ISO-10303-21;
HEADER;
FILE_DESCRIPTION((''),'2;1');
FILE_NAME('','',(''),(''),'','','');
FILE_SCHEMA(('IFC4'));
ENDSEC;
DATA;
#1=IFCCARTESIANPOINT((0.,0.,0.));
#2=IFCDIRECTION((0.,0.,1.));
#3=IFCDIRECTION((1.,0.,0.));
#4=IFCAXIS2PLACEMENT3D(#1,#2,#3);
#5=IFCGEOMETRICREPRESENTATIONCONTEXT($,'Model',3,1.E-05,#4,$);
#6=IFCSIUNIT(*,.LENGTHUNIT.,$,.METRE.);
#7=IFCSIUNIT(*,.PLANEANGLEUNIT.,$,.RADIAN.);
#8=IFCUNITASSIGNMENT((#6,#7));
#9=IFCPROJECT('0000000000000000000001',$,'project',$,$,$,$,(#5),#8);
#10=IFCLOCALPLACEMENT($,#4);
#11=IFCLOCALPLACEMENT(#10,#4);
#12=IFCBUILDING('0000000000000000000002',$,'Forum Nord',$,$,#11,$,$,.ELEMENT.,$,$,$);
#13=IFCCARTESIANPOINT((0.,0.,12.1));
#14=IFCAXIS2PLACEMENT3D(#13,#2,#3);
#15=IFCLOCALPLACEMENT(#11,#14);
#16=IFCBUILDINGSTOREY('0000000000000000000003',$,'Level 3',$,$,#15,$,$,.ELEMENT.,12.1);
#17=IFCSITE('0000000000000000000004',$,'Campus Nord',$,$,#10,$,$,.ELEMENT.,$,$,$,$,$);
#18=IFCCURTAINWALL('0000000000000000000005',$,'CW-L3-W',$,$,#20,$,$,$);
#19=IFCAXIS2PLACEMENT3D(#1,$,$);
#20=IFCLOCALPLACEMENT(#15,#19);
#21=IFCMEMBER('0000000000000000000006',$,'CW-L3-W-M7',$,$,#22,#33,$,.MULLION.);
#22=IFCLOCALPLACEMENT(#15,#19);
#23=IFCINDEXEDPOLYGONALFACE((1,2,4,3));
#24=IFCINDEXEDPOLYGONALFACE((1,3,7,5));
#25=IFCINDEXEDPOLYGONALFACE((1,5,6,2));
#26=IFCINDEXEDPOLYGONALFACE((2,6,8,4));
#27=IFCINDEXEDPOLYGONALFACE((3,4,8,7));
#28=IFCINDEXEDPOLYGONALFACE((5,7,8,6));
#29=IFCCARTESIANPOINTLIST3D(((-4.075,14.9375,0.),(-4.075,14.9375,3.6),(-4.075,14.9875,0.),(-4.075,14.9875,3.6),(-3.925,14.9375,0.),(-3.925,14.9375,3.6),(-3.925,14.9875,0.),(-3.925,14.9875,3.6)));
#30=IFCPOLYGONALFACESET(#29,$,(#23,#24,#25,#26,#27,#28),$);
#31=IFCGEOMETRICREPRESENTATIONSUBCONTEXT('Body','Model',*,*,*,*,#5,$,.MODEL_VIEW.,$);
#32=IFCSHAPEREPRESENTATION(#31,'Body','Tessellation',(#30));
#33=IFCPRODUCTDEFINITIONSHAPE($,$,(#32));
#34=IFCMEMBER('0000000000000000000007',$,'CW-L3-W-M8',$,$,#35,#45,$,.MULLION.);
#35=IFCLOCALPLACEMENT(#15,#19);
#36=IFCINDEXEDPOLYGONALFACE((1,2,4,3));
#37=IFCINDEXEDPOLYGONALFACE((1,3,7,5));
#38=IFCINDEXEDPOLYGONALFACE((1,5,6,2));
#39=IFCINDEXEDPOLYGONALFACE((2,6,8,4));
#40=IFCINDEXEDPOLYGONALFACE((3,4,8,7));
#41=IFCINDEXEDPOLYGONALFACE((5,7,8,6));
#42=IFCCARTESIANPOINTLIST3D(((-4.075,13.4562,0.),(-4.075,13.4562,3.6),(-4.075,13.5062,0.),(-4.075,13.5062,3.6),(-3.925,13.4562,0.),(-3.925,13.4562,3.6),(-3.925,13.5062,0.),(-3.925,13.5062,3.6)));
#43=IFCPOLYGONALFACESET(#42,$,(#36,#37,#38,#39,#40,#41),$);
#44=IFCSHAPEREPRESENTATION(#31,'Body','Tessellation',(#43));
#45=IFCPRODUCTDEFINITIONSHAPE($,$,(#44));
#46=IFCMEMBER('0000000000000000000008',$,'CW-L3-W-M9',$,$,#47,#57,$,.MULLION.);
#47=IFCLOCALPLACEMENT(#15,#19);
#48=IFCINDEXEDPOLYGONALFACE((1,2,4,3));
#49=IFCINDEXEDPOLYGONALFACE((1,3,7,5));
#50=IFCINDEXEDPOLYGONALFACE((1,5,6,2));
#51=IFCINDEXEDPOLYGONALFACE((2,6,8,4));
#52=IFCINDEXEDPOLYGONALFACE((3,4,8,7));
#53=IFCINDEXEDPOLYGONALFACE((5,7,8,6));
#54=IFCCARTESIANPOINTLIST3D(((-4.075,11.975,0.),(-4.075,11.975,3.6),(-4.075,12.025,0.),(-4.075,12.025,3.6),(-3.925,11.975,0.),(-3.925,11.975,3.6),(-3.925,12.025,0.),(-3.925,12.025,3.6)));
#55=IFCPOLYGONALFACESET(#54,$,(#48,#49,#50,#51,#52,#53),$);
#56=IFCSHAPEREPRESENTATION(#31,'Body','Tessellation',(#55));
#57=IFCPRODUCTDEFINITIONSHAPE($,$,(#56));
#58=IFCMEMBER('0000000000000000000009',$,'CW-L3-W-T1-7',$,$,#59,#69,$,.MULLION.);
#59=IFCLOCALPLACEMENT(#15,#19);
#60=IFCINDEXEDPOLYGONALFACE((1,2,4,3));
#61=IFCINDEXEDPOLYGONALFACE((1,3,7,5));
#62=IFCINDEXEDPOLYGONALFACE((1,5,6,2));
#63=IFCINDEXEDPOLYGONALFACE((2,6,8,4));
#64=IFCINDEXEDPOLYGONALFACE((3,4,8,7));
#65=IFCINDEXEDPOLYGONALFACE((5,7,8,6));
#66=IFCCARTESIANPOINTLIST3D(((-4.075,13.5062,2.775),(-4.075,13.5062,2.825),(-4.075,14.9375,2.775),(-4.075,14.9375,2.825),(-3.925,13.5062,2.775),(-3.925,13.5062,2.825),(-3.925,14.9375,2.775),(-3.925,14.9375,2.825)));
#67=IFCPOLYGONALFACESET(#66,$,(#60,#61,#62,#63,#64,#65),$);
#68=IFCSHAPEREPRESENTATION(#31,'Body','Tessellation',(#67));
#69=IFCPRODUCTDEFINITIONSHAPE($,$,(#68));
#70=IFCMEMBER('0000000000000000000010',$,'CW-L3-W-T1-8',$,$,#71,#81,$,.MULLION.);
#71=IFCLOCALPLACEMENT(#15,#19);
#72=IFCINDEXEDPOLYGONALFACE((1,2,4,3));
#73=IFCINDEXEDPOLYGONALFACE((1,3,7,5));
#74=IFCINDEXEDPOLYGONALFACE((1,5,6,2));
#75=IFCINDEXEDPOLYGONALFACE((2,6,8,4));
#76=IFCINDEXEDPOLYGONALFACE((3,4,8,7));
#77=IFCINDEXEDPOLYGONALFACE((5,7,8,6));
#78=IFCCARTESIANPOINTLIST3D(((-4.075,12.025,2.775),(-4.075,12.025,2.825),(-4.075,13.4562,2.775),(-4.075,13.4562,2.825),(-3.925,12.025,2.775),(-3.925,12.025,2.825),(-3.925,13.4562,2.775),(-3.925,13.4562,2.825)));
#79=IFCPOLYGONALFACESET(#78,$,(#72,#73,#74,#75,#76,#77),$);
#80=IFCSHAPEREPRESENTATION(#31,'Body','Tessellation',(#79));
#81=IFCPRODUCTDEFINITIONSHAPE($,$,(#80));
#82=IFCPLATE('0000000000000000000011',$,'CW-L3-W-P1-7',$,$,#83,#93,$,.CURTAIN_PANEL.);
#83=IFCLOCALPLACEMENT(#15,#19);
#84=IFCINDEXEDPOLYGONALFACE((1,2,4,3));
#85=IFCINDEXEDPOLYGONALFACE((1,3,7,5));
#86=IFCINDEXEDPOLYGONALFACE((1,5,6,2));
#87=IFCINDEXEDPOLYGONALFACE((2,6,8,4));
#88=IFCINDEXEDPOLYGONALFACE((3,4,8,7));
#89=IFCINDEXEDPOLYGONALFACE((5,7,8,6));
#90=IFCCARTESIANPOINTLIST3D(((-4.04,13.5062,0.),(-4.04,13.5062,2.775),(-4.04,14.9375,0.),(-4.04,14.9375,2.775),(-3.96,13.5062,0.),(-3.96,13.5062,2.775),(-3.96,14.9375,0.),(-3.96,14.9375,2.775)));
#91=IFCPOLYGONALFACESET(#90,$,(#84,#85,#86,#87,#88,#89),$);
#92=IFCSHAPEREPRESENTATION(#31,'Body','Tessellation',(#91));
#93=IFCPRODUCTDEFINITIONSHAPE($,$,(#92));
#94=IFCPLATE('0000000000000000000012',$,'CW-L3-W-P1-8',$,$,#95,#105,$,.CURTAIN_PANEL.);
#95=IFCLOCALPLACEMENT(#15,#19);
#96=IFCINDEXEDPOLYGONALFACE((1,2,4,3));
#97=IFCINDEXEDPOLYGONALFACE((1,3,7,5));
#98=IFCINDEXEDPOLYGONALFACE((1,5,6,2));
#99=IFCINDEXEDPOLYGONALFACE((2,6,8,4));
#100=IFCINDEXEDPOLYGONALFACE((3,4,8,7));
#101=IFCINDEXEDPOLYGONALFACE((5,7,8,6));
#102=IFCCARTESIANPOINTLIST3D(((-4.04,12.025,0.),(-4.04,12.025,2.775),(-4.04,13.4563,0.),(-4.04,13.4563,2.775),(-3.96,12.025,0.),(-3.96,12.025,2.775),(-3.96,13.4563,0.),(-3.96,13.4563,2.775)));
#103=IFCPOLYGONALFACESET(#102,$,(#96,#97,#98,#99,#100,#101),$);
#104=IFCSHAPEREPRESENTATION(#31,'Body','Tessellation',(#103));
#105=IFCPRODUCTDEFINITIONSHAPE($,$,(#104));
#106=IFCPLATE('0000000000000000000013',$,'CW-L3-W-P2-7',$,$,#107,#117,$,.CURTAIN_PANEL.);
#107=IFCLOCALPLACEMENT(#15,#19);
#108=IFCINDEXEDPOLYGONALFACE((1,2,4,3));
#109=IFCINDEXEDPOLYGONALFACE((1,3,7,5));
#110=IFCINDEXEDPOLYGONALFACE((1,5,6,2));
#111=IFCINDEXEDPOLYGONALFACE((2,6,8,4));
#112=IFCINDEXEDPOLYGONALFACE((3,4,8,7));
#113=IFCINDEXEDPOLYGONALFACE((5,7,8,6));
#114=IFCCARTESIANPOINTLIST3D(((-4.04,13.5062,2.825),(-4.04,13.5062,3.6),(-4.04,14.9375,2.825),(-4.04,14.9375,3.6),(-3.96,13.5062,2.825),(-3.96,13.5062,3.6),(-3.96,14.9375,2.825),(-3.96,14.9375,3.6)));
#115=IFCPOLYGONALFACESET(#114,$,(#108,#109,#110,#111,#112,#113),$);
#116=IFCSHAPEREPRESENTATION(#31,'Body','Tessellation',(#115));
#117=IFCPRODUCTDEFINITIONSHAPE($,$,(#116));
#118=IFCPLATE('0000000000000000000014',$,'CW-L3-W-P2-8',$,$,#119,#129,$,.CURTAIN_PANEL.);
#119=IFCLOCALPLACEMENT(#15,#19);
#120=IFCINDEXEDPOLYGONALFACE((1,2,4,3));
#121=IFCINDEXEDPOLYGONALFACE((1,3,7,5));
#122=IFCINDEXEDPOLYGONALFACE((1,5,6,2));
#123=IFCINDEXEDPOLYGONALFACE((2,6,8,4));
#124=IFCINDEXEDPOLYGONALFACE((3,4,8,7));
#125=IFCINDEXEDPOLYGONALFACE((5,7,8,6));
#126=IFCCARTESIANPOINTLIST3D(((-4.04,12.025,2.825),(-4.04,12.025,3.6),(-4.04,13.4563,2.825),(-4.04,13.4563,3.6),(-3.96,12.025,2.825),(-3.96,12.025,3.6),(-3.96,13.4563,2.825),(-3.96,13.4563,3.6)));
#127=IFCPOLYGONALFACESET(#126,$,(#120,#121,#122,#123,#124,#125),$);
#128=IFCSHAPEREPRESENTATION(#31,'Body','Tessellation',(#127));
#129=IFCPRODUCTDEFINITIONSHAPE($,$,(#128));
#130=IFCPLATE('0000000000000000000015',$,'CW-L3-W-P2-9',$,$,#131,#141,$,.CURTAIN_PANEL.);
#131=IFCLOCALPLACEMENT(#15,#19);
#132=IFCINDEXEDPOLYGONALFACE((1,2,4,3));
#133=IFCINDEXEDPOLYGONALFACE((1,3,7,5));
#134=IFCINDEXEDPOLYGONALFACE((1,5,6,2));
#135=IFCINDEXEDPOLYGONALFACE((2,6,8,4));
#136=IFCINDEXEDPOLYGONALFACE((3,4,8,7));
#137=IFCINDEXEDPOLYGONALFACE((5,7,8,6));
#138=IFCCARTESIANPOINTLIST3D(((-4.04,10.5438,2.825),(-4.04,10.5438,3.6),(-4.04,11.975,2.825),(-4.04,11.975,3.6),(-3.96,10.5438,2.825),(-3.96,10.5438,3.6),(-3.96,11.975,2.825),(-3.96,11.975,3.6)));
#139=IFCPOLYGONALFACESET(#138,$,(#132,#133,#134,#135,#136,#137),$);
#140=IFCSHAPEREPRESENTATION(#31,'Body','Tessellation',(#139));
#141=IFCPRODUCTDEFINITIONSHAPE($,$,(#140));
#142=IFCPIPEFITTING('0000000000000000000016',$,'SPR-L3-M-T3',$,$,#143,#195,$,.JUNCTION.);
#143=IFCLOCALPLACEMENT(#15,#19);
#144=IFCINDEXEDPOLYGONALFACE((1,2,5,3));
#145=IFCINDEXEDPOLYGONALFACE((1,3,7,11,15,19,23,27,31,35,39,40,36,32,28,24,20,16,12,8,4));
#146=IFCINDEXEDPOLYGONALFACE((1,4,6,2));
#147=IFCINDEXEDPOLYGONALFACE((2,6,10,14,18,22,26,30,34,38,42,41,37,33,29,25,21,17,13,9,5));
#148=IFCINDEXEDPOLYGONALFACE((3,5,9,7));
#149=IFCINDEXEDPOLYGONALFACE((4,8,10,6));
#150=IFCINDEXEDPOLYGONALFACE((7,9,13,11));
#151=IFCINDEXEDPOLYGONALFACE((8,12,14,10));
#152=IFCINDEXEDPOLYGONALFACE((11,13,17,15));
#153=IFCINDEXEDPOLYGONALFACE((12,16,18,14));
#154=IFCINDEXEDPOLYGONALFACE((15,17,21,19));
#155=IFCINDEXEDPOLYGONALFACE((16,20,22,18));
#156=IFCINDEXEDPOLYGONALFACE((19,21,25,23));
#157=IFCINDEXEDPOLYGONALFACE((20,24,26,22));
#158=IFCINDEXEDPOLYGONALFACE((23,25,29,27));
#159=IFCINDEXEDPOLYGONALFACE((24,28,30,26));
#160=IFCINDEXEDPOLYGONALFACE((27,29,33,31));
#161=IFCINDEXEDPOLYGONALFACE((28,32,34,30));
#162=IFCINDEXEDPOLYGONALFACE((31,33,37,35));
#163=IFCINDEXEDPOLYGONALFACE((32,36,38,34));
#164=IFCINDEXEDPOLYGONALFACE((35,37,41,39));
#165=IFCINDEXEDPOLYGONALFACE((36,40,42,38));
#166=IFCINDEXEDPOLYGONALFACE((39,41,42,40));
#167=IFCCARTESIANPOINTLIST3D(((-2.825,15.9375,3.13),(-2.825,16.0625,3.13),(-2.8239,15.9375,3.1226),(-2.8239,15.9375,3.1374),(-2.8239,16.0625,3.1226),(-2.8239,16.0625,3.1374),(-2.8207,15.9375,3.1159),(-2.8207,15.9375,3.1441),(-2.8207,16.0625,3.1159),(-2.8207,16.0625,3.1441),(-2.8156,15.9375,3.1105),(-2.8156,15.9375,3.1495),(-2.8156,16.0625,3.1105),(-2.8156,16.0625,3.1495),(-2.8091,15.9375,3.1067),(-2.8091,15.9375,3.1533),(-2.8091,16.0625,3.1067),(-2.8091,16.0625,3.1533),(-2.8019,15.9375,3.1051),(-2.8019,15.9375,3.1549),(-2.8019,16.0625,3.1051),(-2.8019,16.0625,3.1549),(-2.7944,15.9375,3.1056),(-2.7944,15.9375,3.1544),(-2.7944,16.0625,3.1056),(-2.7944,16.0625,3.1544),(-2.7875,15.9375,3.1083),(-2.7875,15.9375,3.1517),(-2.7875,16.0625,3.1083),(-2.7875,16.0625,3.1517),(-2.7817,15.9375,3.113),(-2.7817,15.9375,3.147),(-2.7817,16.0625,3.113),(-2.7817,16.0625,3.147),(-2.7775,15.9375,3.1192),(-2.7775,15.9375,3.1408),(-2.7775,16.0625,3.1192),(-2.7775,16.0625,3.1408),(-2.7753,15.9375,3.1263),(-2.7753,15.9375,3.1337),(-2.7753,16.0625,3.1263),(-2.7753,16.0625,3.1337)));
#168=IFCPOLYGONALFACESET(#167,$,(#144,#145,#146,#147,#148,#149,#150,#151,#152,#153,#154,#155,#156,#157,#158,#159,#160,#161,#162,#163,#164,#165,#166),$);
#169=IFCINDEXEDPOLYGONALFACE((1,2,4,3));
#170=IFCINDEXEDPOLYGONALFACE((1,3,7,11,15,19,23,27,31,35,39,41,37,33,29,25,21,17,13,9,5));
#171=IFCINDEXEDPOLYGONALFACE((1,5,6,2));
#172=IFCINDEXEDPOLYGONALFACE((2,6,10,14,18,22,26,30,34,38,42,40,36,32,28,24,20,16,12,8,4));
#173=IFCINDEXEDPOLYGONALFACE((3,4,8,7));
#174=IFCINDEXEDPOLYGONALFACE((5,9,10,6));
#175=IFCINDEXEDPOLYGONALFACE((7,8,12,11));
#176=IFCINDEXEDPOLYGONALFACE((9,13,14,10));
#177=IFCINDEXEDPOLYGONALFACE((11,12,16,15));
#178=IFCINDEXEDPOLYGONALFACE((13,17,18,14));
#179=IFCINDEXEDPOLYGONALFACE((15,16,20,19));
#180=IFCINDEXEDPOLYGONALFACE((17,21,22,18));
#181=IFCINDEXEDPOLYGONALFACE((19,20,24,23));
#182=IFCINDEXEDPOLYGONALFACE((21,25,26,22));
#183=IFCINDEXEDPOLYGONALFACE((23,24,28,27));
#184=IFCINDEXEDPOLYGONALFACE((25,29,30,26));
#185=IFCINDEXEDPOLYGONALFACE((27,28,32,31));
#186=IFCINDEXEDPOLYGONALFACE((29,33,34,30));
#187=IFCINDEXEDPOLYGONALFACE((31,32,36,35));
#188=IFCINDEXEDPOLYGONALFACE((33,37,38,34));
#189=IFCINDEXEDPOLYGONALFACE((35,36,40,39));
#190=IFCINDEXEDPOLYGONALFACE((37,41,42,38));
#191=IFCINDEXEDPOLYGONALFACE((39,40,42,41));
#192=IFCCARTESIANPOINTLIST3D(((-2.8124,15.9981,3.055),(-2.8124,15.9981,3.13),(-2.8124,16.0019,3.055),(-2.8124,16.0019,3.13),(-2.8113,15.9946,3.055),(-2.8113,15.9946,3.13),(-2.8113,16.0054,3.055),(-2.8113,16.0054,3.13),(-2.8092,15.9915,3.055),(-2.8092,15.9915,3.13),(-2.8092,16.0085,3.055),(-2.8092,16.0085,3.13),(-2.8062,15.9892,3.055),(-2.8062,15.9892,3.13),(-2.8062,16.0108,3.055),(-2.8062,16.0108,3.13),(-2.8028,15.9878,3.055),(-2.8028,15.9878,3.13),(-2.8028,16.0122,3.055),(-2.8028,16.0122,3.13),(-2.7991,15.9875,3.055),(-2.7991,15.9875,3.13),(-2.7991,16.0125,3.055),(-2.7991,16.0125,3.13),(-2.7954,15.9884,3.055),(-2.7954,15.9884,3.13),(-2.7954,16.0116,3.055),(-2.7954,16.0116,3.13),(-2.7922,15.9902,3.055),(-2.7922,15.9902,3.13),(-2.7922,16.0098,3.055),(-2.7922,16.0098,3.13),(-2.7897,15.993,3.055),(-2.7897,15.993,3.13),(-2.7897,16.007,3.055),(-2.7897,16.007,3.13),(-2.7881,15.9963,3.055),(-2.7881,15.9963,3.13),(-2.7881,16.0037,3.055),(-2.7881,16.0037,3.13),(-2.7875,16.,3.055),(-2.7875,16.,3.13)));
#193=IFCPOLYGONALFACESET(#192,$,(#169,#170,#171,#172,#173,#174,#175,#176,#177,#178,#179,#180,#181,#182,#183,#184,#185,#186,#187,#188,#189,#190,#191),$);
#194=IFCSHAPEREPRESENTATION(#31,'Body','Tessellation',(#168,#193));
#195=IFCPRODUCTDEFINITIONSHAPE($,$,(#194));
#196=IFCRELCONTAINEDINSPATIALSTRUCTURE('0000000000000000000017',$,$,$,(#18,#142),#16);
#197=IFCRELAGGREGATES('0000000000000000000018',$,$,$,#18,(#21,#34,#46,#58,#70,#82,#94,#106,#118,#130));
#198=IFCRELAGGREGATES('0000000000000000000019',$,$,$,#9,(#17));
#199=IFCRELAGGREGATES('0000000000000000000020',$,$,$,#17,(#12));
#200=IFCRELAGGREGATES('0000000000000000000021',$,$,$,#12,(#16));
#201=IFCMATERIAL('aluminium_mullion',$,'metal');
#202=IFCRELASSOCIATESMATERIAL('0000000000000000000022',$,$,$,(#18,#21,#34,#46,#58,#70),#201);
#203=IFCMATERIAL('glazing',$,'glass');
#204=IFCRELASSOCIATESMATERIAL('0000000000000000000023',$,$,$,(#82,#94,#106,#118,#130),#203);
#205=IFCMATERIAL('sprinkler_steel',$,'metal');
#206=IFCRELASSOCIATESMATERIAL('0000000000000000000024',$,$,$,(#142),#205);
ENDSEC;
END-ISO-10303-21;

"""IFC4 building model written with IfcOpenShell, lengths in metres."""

from ifc_helpers import new_model, si_unit, frame, frame_2d, origin_with_axes, origin_2d_with_axis, place, context, subcontext, project, spatial, rectangle, circle, extrude, material, element, aggregate, save


model = new_model("IFC4")

# Units and contexts
model_context = context("Model", 3, precision=1e-05, world=origin_with_axes())
body_context = subcontext(model_context, "Body", "Model", "MODEL_VIEW")
ifc_project = project(units=[si_unit("LENGTHUNIT", "METRE"), si_unit("PLANEANGLEUNIT", "RADIAN")], contexts=[model_context])

# Site, building, storey
site_placement = place(None, origin_with_axes())
site = spatial("IfcSite", under=ifc_project, at=site_placement, Name="Campus Nord", CompositionType="ELEMENT")
building_placement = place(site_placement, origin_with_axes())
building = spatial("IfcBuilding", under=site, at=building_placement, Name="Forum Nord", CompositionType="ELEMENT")
storey_placement = place(building_placement, frame((0.0, 0.0, 12.1), z_axis=(0.0, 0.0, 1.0), x_axis=(1.0, 0.0, 0.0)))
storey = spatial("IfcBuildingStorey", under=building, at=storey_placement, Name="Level 3", CompositionType="ELEMENT", Elevation=12.1)

# Curtain wall, members, plates
ifc_material_1 = material(Name="aluminium_mullion", Category="metal")
curtain_wall_placement = place(storey_placement, origin_with_axes())
curtain_wall = element("IfcCurtainWall", 1, at=curtain_wall_placement, inside=storey, material=ifc_material_1, Name="CW-L3-W")
member_1_placement = place(storey_placement, frame((-4.0, 14.9625, 0.0), z_axis=(0.0, 0.0, 1.0), x_axis=(0.0, -1.0, 0.0)))
member_1 = element("IfcMember", 2, at=member_1_placement, material=ifc_material_1, Name="CW-L3-W-M7", PredefinedType="MULLION", context=body_context, shape_type="SweptSolid", body=[
    extrude(rectangle(XDim=0.05, YDim=0.15, at=origin_2d_with_axis()), origin_with_axes(), (0.0, 0.0, 1.0), 3.6),
])
member_2_placement = place(storey_placement, frame((-4.0, 13.4812, 0.0), z_axis=(0.0, 0.0, 1.0), x_axis=(0.0, -1.0, 0.0)))
member_2 = element("IfcMember", 3, at=member_2_placement, material=ifc_material_1, Name="CW-L3-W-M8", PredefinedType="MULLION", context=body_context, shape_type="SweptSolid", body=[
    extrude(rectangle(XDim=0.05, YDim=0.15, at=origin_2d_with_axis()), origin_with_axes(), (0.0, 0.0, 1.0), 3.6),
])
member_3_placement = place(storey_placement, frame((-4.0, 12.0, 0.0), z_axis=(0.0, 0.0, 1.0), x_axis=(0.0, -1.0, 0.0)))
member_3 = element("IfcMember", 4, at=member_3_placement, material=ifc_material_1, Name="CW-L3-W-M9", PredefinedType="MULLION", context=body_context, shape_type="SweptSolid", body=[
    extrude(rectangle(XDim=0.05, YDim=0.15, at=origin_2d_with_axis()), origin_with_axes(), (0.0, 0.0, 1.0), 3.6),
])
member_4_placement = place(storey_placement, frame((-4.0, 14.9375, 2.8), z_axis=(0.0, -1.0, 0.0), x_axis=(1.0, 0.0, 0.0)))
member_4 = element("IfcMember", 5, at=member_4_placement, material=ifc_material_1, Name="CW-L3-W-T1-7", PredefinedType="MULLION", context=body_context, shape_type="SweptSolid", body=[
    extrude(rectangle(XDim=0.15, YDim=0.05, at=origin_2d_with_axis()), origin_with_axes(), (0.0, 0.0, 1.0), 1.4312),
])
member_5_placement = place(storey_placement, frame((-4.0, 13.4563, 2.8), z_axis=(0.0, -1.0, 0.0), x_axis=(1.0, 0.0, 0.0)))
member_5 = element("IfcMember", 6, at=member_5_placement, material=ifc_material_1, Name="CW-L3-W-T1-8", PredefinedType="MULLION", context=body_context, shape_type="SweptSolid", body=[
    extrude(rectangle(XDim=0.15, YDim=0.05, at=origin_2d_with_axis()), origin_with_axes(), (0.0, 0.0, 1.0), 1.4312),
])
ifc_material_2 = material(Name="glazing", Category="glass")
plate_1_placement = place(storey_placement, frame((-4.0, 14.9375, 0.0), z_axis=(0.0, 0.0, 1.0), x_axis=(0.0, -1.0, 0.0)))
plate_1 = element("IfcPlate", 7, at=plate_1_placement, material=ifc_material_2, Name="CW-L3-W-P1-7", PredefinedType="CURTAIN_PANEL", context=body_context, shape_type="SweptSolid", body=[
    extrude(rectangle(XDim=1.4312, YDim=0.08, at=frame_2d((0.7156, 0.0), x_axis=(1.0, 0.0))), origin_with_axes(), (0.0, 0.0, 1.0), 2.775),
])
plate_2_placement = place(storey_placement, frame((-4.0, 13.4563, 0.0), z_axis=(0.0, 0.0, 1.0), x_axis=(0.0, -1.0, 0.0)))
plate_2 = element("IfcPlate", 8, at=plate_2_placement, material=ifc_material_2, Name="CW-L3-W-P1-8", PredefinedType="CURTAIN_PANEL", context=body_context, shape_type="SweptSolid", body=[
    extrude(rectangle(XDim=1.4312, YDim=0.08, at=frame_2d((0.7156, 0.0), x_axis=(1.0, 0.0))), origin_with_axes(), (0.0, 0.0, 1.0), 2.775),
])
plate_3_placement = place(storey_placement, frame((-4.0, 14.9375, 2.825), z_axis=(0.0, 0.0, 1.0), x_axis=(0.0, -1.0, 0.0)))
plate_3 = element("IfcPlate", 9, at=plate_3_placement, material=ifc_material_2, Name="CW-L3-W-P2-7", PredefinedType="CURTAIN_PANEL", context=body_context, shape_type="SweptSolid", body=[
    extrude(rectangle(XDim=1.4312, YDim=0.08, at=frame_2d((0.7156, 0.0), x_axis=(1.0, 0.0))), origin_with_axes(), (0.0, 0.0, 1.0), 0.775),
])
plate_4_placement = place(storey_placement, frame((-4.0, 13.4563, 2.825), z_axis=(0.0, 0.0, 1.0), x_axis=(0.0, -1.0, 0.0)))
plate_4 = element("IfcPlate", 10, at=plate_4_placement, material=ifc_material_2, Name="CW-L3-W-P2-8", PredefinedType="CURTAIN_PANEL", context=body_context, shape_type="SweptSolid", body=[
    extrude(rectangle(XDim=1.4312, YDim=0.08, at=frame_2d((0.7156, 0.0), x_axis=(1.0, 0.0))), origin_with_axes(), (0.0, 0.0, 1.0), 0.775),
])
plate_5_placement = place(storey_placement, frame((-4.0, 11.975, 2.825), z_axis=(0.0, 0.0, 1.0), x_axis=(0.0, -1.0, 0.0)))
plate_5 = element("IfcPlate", 11, at=plate_5_placement, material=ifc_material_2, Name="CW-L3-W-P2-9", PredefinedType="CURTAIN_PANEL", context=body_context, shape_type="SweptSolid", body=[
    extrude(rectangle(XDim=1.4312, YDim=0.08, at=frame_2d((0.7156, 0.0), x_axis=(1.0, 0.0))), origin_with_axes(), (0.0, 0.0, 1.0), 0.775),
])
aggregate(curtain_wall, [member_1, member_2, member_3, member_4, member_5, plate_1, plate_2, plate_3, plate_4, plate_5])

# Pipe fitting
ifc_material_3 = material(Name="sprinkler_steel", Category="metal")
pipe_fitting_placement = place(storey_placement, frame((-2.8, 15.9375, 3.13), z_axis=(0.0, 1.0, 0.0), x_axis=(-1.0, 0.0, 0.0)))
element("IfcPipeFitting", 12, at=pipe_fitting_placement, inside=storey, material=ifc_material_3, Name="SPR-L3-M-T3", PredefinedType="JUNCTION", context=body_context, shape_type="SweptSolid", body=[
    extrude(circle(Radius=0.025, at=origin_2d_with_axis()), origin_with_axes(), (0.0, 0.0, 1.0), 0.125),
    extrude(circle(Radius=0.0125, at=origin_2d_with_axis()), frame((0.0, 0.0, 0.0625), z_axis=(0.0, -1.0, 0.0), x_axis=(-1.0, 0.0, 0.0)), (0.0, 0.0, 1.0), 0.075),
])

save(model, "model.ifc")
